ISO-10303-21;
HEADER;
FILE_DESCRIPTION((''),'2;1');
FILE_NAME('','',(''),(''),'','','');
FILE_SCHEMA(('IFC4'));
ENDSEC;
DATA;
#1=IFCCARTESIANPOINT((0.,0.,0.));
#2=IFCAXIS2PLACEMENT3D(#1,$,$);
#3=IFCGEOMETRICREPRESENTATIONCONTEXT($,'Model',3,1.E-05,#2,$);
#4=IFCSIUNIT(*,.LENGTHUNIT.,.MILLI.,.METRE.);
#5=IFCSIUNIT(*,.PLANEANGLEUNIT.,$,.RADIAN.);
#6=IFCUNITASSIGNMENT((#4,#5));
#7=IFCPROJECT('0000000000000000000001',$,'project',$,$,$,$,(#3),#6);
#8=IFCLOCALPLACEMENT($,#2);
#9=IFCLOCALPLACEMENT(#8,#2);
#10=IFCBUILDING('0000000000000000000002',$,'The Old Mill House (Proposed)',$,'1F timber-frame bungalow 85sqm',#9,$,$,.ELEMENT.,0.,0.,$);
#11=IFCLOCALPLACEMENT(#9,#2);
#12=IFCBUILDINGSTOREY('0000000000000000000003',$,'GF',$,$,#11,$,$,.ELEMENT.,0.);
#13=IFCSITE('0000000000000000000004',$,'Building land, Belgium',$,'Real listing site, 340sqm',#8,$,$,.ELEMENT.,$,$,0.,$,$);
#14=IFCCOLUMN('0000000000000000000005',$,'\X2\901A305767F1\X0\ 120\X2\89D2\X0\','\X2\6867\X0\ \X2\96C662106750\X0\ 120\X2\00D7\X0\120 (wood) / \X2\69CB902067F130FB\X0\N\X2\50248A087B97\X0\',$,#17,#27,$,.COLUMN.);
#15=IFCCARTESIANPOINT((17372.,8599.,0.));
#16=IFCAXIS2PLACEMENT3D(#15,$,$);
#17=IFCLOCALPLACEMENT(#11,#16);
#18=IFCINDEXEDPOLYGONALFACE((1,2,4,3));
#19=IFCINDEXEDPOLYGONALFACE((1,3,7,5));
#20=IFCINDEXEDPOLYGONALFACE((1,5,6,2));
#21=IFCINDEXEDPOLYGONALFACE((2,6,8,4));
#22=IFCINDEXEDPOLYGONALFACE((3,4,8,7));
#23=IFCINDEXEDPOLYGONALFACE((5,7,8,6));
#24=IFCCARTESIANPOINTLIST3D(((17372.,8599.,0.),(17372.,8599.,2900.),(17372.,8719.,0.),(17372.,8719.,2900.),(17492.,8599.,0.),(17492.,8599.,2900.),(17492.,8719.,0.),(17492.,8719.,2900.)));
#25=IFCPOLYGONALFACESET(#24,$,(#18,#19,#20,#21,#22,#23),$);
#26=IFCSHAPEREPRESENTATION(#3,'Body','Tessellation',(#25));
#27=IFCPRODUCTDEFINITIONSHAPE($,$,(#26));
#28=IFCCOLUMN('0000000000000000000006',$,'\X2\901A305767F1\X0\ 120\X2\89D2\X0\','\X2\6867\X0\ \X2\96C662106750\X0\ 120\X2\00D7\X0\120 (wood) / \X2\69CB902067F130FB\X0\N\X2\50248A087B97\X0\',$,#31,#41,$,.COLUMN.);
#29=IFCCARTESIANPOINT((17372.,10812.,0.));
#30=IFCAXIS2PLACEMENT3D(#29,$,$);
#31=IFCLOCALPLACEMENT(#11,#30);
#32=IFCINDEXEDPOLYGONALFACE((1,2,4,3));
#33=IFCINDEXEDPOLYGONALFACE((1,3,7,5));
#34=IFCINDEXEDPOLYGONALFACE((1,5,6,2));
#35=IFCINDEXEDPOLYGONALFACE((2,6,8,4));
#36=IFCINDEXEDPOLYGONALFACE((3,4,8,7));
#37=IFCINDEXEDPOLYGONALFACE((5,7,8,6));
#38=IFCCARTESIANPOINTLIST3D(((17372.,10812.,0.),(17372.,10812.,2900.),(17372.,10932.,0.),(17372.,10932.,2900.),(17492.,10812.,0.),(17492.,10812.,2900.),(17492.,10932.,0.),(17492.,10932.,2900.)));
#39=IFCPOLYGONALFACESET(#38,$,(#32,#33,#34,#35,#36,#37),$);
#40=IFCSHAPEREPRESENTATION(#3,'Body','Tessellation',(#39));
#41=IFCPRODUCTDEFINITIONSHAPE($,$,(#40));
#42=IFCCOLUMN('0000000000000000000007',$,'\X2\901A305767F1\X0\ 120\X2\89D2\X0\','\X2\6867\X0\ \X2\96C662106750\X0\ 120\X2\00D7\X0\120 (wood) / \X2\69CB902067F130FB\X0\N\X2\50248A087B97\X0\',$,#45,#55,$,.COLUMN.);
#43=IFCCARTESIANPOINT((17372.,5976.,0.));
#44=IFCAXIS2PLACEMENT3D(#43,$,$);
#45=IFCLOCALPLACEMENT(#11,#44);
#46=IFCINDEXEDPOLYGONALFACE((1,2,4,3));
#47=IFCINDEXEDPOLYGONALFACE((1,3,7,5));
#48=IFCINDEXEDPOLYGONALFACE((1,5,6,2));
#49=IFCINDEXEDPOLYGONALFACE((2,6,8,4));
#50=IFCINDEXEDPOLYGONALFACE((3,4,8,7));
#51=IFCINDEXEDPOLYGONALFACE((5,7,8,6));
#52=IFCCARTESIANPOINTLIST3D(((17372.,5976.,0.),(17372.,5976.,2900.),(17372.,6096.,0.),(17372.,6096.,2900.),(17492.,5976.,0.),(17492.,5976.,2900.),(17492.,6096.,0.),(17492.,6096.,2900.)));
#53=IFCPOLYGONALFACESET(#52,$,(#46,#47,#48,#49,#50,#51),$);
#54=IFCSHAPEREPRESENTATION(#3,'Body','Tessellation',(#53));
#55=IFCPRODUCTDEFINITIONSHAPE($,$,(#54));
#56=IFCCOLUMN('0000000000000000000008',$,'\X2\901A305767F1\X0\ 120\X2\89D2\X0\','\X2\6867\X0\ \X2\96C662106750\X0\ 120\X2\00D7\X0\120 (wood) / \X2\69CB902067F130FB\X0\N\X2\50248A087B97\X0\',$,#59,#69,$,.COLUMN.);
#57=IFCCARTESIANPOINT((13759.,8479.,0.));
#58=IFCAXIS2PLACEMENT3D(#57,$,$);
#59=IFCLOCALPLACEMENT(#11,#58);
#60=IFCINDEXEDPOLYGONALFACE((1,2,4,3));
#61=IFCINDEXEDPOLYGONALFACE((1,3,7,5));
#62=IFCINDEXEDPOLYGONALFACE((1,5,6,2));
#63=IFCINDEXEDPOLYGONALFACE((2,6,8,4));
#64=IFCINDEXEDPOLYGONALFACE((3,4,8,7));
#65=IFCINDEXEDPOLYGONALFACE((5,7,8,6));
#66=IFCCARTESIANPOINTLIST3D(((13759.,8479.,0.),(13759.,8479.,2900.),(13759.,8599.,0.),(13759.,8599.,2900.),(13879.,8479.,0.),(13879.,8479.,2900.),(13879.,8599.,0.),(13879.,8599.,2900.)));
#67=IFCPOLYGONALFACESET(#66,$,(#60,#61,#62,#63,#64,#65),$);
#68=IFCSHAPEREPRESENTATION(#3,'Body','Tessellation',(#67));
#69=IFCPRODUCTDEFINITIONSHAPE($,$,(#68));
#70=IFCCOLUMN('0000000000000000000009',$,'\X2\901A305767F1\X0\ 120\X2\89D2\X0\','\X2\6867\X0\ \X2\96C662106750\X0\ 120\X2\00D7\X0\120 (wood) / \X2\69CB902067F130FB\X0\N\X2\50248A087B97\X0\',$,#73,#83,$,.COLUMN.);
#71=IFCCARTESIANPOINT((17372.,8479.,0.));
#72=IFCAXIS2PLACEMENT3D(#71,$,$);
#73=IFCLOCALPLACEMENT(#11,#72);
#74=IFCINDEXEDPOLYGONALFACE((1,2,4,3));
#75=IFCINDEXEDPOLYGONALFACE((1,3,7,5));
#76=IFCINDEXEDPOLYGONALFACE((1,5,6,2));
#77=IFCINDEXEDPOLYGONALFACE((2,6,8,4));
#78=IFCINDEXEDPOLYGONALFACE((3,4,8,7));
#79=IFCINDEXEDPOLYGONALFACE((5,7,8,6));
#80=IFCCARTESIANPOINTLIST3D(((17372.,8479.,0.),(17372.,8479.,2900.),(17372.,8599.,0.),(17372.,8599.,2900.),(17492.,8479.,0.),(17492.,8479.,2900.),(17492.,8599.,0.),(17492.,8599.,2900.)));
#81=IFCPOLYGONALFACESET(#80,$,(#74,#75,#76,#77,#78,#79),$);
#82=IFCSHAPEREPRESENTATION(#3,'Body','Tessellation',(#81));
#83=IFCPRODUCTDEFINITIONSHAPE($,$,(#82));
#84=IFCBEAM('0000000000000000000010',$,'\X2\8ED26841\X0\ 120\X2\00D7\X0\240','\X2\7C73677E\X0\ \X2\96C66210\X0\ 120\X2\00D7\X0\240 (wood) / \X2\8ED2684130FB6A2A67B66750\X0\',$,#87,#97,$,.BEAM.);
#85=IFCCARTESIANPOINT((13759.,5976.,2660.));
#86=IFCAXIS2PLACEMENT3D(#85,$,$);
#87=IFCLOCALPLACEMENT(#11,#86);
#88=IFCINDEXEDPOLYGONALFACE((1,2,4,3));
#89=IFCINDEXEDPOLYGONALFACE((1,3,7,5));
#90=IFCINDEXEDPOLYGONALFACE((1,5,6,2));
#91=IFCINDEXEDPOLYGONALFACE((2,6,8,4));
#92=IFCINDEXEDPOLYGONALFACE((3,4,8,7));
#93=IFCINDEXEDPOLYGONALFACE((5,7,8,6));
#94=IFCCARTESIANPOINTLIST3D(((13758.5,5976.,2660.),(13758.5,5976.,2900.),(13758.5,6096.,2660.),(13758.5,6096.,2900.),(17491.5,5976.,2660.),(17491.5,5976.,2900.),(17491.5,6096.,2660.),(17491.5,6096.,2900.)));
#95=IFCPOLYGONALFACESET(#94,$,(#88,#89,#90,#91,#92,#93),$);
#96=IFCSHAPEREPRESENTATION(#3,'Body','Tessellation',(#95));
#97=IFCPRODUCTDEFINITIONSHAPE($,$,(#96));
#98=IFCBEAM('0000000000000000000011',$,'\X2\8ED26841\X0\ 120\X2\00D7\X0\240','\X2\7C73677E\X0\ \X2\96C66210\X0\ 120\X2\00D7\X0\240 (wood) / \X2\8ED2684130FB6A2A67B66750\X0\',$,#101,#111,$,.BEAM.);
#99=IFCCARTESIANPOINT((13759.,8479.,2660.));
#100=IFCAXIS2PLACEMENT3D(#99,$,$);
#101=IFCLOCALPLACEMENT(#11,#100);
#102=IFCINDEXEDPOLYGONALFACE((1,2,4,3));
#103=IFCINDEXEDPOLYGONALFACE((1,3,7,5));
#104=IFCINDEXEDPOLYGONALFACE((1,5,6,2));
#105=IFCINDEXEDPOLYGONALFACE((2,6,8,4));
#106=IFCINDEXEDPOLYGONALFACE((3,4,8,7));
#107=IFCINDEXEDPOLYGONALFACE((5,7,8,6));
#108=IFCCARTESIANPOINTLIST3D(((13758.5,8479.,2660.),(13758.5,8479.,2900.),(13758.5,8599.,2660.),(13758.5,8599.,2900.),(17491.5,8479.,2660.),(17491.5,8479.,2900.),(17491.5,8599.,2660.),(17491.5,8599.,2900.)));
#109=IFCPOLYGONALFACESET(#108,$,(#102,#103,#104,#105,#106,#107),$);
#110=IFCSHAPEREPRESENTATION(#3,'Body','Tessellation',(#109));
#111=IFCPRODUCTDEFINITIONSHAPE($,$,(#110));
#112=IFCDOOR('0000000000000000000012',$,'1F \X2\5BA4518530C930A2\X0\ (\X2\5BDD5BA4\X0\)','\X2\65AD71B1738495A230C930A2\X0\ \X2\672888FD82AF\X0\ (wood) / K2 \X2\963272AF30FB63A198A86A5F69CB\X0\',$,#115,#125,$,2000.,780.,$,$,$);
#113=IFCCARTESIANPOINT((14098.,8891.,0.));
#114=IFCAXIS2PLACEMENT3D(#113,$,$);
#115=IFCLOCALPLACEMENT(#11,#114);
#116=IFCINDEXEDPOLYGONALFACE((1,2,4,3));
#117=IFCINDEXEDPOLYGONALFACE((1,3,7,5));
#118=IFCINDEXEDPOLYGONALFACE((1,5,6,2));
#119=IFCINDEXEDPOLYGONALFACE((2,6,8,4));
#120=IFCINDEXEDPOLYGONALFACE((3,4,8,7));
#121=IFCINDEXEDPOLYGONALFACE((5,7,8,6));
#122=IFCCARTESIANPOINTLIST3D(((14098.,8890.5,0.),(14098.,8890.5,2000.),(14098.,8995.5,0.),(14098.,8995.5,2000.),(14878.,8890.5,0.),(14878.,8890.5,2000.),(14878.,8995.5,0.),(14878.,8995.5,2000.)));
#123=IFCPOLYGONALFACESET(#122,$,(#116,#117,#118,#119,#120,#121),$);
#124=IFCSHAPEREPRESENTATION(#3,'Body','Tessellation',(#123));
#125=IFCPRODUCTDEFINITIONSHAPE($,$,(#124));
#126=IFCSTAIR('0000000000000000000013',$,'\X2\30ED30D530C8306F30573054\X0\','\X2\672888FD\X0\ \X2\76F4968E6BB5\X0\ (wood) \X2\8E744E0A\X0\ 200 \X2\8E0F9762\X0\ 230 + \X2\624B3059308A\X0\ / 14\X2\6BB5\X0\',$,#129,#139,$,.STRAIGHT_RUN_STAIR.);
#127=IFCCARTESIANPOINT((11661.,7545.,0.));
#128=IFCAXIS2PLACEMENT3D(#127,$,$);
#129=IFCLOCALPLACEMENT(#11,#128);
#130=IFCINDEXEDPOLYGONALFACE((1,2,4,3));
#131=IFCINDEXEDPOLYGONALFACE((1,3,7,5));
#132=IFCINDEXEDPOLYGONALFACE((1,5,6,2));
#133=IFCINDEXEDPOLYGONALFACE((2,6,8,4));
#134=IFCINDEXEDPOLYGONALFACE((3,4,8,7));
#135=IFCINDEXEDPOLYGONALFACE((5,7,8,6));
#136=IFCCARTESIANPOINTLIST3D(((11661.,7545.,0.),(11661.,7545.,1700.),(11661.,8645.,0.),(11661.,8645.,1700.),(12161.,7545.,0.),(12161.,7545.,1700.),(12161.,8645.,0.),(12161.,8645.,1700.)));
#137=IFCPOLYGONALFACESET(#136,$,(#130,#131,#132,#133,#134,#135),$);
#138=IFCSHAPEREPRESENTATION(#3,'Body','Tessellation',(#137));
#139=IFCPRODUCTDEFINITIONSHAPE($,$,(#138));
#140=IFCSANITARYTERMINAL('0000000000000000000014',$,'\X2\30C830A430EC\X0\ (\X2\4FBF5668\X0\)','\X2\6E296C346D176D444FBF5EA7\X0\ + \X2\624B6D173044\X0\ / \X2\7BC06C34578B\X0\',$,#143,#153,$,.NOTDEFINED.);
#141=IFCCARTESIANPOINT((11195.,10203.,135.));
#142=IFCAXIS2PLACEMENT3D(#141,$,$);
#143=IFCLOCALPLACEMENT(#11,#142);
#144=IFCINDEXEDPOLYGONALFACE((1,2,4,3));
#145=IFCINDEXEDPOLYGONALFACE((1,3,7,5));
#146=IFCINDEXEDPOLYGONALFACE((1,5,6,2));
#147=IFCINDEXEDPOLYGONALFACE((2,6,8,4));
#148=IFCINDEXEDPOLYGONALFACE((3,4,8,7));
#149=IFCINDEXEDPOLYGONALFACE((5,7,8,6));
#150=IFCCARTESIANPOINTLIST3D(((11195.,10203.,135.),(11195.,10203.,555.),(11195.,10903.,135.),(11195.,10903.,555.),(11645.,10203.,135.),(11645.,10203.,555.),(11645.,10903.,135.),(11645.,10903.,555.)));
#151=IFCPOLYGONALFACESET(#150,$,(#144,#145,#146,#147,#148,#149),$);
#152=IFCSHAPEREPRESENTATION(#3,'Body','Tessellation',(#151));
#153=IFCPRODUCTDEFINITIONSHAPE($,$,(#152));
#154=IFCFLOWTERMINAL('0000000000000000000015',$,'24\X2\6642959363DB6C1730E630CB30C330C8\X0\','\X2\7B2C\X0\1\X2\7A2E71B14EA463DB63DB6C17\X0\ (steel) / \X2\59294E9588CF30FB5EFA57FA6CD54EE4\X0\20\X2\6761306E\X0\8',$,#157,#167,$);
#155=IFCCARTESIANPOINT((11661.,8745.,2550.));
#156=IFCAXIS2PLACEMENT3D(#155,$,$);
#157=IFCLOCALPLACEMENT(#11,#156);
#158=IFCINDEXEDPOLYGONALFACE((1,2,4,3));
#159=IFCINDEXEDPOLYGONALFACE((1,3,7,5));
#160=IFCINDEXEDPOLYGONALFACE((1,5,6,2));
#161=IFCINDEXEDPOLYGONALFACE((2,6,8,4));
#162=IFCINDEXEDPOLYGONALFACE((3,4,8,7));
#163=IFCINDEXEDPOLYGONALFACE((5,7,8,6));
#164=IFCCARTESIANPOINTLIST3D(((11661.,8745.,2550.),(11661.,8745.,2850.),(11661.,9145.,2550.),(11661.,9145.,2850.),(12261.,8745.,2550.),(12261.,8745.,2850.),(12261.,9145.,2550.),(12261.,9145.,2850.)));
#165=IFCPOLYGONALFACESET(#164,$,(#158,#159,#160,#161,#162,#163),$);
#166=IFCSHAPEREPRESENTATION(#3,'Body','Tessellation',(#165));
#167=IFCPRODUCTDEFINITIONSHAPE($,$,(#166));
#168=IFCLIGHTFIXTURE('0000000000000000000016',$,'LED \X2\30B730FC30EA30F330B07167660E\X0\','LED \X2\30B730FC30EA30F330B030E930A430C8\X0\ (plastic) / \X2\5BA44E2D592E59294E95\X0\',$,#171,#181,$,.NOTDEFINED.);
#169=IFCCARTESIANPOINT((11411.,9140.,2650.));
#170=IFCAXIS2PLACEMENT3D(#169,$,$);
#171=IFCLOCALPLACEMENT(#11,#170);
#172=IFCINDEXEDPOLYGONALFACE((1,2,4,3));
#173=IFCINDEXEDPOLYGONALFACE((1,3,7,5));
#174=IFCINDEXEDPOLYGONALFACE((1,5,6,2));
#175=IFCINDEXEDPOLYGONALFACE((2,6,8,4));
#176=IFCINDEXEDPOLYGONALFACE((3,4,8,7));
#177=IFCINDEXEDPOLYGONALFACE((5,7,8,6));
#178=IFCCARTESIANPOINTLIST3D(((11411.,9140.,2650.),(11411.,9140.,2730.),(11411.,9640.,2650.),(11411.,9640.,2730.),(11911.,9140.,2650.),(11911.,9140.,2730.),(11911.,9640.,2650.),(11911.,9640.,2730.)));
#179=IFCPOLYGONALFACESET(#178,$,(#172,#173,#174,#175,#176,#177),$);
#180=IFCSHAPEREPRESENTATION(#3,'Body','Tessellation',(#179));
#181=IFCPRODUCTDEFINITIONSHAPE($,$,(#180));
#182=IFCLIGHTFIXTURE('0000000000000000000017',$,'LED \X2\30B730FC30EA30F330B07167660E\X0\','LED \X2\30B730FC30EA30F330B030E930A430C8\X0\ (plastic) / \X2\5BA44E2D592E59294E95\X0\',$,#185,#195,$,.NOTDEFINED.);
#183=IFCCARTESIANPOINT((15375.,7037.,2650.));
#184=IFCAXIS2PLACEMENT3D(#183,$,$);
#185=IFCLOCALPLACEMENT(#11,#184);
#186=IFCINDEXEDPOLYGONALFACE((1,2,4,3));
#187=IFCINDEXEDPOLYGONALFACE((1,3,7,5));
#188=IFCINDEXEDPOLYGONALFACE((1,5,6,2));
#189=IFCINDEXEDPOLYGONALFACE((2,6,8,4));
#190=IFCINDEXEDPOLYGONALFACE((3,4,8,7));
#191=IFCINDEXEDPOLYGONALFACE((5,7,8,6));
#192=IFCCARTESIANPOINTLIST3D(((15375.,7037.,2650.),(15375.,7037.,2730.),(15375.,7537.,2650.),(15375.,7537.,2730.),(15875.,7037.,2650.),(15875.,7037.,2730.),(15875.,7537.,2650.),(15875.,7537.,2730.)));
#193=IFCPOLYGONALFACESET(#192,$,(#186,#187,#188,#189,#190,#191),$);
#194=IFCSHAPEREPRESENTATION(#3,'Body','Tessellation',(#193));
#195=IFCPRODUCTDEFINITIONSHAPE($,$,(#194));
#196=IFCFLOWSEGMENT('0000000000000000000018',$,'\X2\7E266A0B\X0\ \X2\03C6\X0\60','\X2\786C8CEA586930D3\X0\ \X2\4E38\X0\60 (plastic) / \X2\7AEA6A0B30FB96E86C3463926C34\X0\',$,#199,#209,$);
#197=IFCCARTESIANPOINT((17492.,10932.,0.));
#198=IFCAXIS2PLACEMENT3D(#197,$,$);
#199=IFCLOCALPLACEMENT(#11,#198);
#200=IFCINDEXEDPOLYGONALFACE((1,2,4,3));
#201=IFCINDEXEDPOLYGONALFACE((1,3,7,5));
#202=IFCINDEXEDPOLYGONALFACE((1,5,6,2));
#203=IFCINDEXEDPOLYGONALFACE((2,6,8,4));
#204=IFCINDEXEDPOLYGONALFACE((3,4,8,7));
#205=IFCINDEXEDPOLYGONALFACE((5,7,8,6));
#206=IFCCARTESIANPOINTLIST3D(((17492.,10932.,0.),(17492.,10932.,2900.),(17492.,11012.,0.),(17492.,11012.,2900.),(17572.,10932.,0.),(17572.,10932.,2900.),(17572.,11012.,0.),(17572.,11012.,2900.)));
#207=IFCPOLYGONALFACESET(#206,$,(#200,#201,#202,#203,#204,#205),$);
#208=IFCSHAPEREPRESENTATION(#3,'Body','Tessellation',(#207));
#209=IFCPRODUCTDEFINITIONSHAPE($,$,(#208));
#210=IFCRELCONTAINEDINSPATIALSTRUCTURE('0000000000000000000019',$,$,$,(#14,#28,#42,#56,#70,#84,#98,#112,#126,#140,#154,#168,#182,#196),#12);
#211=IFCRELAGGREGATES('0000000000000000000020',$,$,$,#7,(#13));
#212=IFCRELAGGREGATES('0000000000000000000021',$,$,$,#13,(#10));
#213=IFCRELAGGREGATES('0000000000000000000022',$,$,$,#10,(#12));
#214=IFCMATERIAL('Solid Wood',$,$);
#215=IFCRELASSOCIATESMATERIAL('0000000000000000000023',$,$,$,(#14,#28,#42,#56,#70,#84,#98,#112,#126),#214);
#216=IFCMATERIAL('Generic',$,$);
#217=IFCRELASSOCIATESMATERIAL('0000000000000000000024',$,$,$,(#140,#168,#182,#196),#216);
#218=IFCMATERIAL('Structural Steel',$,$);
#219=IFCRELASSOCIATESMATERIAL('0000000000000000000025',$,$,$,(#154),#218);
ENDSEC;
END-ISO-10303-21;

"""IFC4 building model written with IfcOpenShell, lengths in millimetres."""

from ifc_helpers import new_model, si_unit, frame, frame_2d, origin, place, context, project, spatial, rectangle, extrude, material, element, save


model = new_model("IFC4")

# Units and contexts
model_context = context("Model", 3, precision=1e-05, world=origin())
ifc_project = project(units=[si_unit("LENGTHUNIT", "METRE", prefix="MILLI"), si_unit("PLANEANGLEUNIT", "RADIAN")], contexts=[model_context])

# Site, building, storey
site_placement = place(None, origin())
site = spatial("IfcSite", under=ifc_project, at=site_placement, Name="Building land, Belgium", ObjectType="Real listing site, 340sqm", CompositionType="ELEMENT", RefElevation=0.0)
building_placement = place(site_placement, origin())
building = spatial("IfcBuilding", under=site, at=building_placement, Name="The Old Mill House (Proposed)", ObjectType="1F timber-frame bungalow 85sqm", CompositionType="ELEMENT", ElevationOfRefHeight=0.0, ElevationOfTerrain=0.0)
storey_placement = place(building_placement, origin())
storey = spatial("IfcBuildingStorey", under=building, at=storey_placement, Name="GF", CompositionType="ELEMENT", Elevation=0.0)

# Columns
ifc_material_1 = material(Name="Solid Wood")
column_1_placement = place(storey_placement, frame((17372.0, 8599.0, 0.0)))
element("IfcColumn", 1, at=column_1_placement, inside=storey, material=ifc_material_1, Name="通し柱 120角", Description="桧 集成材 120×120 (wood) / 構造柱・N値計算", PredefinedType="COLUMN", context=model_context, shape_type="SweptSolid", body=[
    extrude(rectangle(XDim=120.0, YDim=120.0, at=frame_2d((60.0, 60.0))), frame((17372.0, 8599.0, 0.0)), (0.0, 0.0, 1.0), 2900.0),
])
column_2_placement = place(storey_placement, frame((17372.0, 10812.0, 0.0)))
element("IfcColumn", 2, at=column_2_placement, inside=storey, material=ifc_material_1, Name="通し柱 120角", Description="桧 集成材 120×120 (wood) / 構造柱・N値計算", PredefinedType="COLUMN", context=model_context, shape_type="SweptSolid", body=[
    extrude(rectangle(XDim=120.0, YDim=120.0, at=frame_2d((60.0, 60.0))), frame((17372.0, 10812.0, 0.0)), (0.0, 0.0, 1.0), 2900.0),
])
column_3_placement = place(storey_placement, frame((17372.0, 5976.0, 0.0)))
element("IfcColumn", 3, at=column_3_placement, inside=storey, material=ifc_material_1, Name="通し柱 120角", Description="桧 集成材 120×120 (wood) / 構造柱・N値計算", PredefinedType="COLUMN", context=model_context, shape_type="SweptSolid", body=[
    extrude(rectangle(XDim=120.0, YDim=120.0, at=frame_2d((60.0, 60.0))), frame((17372.0, 5976.0, 0.0)), (0.0, 0.0, 1.0), 2900.0),
])
column_4_placement = place(storey_placement, frame((13759.0, 8479.0, 0.0)))
element("IfcColumn", 4, at=column_4_placement, inside=storey, material=ifc_material_1, Name="通し柱 120角", Description="桧 集成材 120×120 (wood) / 構造柱・N値計算", PredefinedType="COLUMN", context=model_context, shape_type="SweptSolid", body=[
    extrude(rectangle(XDim=120.0, YDim=120.0, at=frame_2d((60.0, 60.0))), frame((13759.0, 8479.0, 0.0)), (0.0, 0.0, 1.0), 2900.0),
])
column_5_placement = place(storey_placement, frame((17372.0, 8479.0, 0.0)))
element("IfcColumn", 5, at=column_5_placement, inside=storey, material=ifc_material_1, Name="通し柱 120角", Description="桧 集成材 120×120 (wood) / 構造柱・N値計算", PredefinedType="COLUMN", context=model_context, shape_type="SweptSolid", body=[
    extrude(rectangle(XDim=120.0, YDim=120.0, at=frame_2d((60.0, 60.0))), frame((17372.0, 8479.0, 0.0)), (0.0, 0.0, 1.0), 2900.0),
])

# Beams
beam_1_placement = place(storey_placement, frame((13759.0, 5976.0, 2660.0)))
element("IfcBeam", 6, at=beam_1_placement, inside=storey, material=ifc_material_1, Name="軒桁 120×240", Description="米松 集成 120×240 (wood) / 軒桁・横架材", PredefinedType="BEAM", context=model_context, shape_type="SweptSolid", body=[
    extrude(rectangle(XDim=3733.0, YDim=120.0, at=frame_2d((1866.0, 60.0))), frame((13759.0, 5976.0, 2660.0)), (0.0, 0.0, 1.0), 240.0),
])
beam_2_placement = place(storey_placement, frame((13759.0, 8479.0, 2660.0)))
element("IfcBeam", 7, at=beam_2_placement, inside=storey, material=ifc_material_1, Name="軒桁 120×240", Description="米松 集成 120×240 (wood) / 軒桁・横架材", PredefinedType="BEAM", context=model_context, shape_type="SweptSolid", body=[
    extrude(rectangle(XDim=3733.0, YDim=120.0, at=frame_2d((1866.0, 60.0))), frame((13759.0, 8479.0, 2660.0)), (0.0, 0.0, 1.0), 240.0),
])

# Door
door_placement = place(storey_placement, frame((14098.0, 8891.0, 0.0)))
element("IfcDoor", 8, at=door_placement, inside=storey, material=ifc_material_1, Name="1F 室内ドア (寝室)", Description="断熱玄関ドア 木製芯 (wood) / K2 防犯・採風機構", OverallHeight=2000.0, OverallWidth=780.0, context=model_context, shape_type="SweptSolid", body=[
    extrude(rectangle(XDim=780.0, YDim=105.0, at=frame_2d((390.0, 52.0))), frame((14098.0, 8891.0, 0.0)), (0.0, 0.0, 1.0), 2000.0),
])

# Stair
stair_placement = place(storey_placement, frame((11661.0, 7545.0, 0.0)))
element("IfcStair", 9, at=stair_placement, inside=storey, material=ifc_material_1, Name="ロフトはしご", Description="木製 直階段 (wood) 蹴上 200 踏面 230 + 手すり / 14段", PredefinedType="STRAIGHT_RUN_STAIR", context=model_context, shape_type="SweptSolid", body=[
    extrude(rectangle(XDim=500.0, YDim=1100.0, at=frame_2d((250.0, 550.0))), frame((11661.0, 7545.0, 0.0)), (0.0, 0.0, 1.0), 1700.0),
])

# Shared definitions
ifc_material_2 = material(Name="Generic")

# Sanitary terminal
sanitary_terminal_placement = place(storey_placement, frame((11195.0, 10203.0, 135.0)))
element("IfcSanitaryTerminal", 10, at=sanitary_terminal_placement, inside=storey, material=ifc_material_2, Name="トイレ (便器)", Description="温水洗浄便座 + 手洗い / 節水型", PredefinedType="NOTDEFINED", context=model_context, shape_type="SweptSolid", body=[
    extrude(rectangle(XDim=450.0, YDim=700.0, at=frame_2d((225.0, 350.0))), frame((11195.0, 10203.0, 135.0)), (0.0, 0.0, 1.0), 420.0),
])

# Flow terminal
ifc_material_3 = material(Name="Structural Steel")
flow_terminal_placement = place(storey_placement, frame((11661.0, 8745.0, 2550.0)))
element("IfcFlowTerminal", 11, at=flow_terminal_placement, inside=storey, material=ifc_material_3, Name="24時間換気ユニット", Description="第1種熱交換換気 (steel) / 天井裏・建基法令20条の8", context=model_context, shape_type="SweptSolid", body=[
    extrude(rectangle(XDim=600.0, YDim=400.0, at=frame_2d((300.0, 200.0))), frame((11661.0, 8745.0, 2550.0)), (0.0, 0.0, 1.0), 300.0),
])

# Light fixtures
light_fixture_1_placement = place(storey_placement, frame((11411.0, 9140.0, 2650.0)))
element("IfcLightFixture", 12, at=light_fixture_1_placement, inside=storey, material=ifc_material_2, Name="LED シーリング照明", Description="LED シーリングライト (plastic) / 室中央天井", PredefinedType="NOTDEFINED", context=model_context, shape_type="SweptSolid", body=[
    extrude(rectangle(XDim=500.0, YDim=500.0, at=frame_2d((250.0, 250.0))), frame((11411.0, 9140.0, 2650.0)), (0.0, 0.0, 1.0), 80.0),
])
light_fixture_2_placement = place(storey_placement, frame((15375.0, 7037.0, 2650.0)))
element("IfcLightFixture", 13, at=light_fixture_2_placement, inside=storey, material=ifc_material_2, Name="LED シーリング照明", Description="LED シーリングライト (plastic) / 室中央天井", PredefinedType="NOTDEFINED", context=model_context, shape_type="SweptSolid", body=[
    extrude(rectangle(XDim=500.0, YDim=500.0, at=frame_2d((250.0, 250.0))), frame((15375.0, 7037.0, 2650.0)), (0.0, 0.0, 1.0), 80.0),
])

# Flow segment
flow_segment_placement = place(storey_placement, frame((17492.0, 10932.0, 0.0)))
element("IfcFlowSegment", 14, at=flow_segment_placement, inside=storey, material=ifc_material_2, Name="縦樋 φ60", Description="硬質塩ビ 丸60 (plastic) / 竪樋・雨水排水", context=model_context, shape_type="SweptSolid", body=[
    extrude(rectangle(XDim=80.0, YDim=80.0, at=frame_2d((40.0, 40.0))), frame((17492.0, 10932.0, 0.0)), (0.0, 0.0, 1.0), 2900.0),
])

save(model, "model.ifc")
